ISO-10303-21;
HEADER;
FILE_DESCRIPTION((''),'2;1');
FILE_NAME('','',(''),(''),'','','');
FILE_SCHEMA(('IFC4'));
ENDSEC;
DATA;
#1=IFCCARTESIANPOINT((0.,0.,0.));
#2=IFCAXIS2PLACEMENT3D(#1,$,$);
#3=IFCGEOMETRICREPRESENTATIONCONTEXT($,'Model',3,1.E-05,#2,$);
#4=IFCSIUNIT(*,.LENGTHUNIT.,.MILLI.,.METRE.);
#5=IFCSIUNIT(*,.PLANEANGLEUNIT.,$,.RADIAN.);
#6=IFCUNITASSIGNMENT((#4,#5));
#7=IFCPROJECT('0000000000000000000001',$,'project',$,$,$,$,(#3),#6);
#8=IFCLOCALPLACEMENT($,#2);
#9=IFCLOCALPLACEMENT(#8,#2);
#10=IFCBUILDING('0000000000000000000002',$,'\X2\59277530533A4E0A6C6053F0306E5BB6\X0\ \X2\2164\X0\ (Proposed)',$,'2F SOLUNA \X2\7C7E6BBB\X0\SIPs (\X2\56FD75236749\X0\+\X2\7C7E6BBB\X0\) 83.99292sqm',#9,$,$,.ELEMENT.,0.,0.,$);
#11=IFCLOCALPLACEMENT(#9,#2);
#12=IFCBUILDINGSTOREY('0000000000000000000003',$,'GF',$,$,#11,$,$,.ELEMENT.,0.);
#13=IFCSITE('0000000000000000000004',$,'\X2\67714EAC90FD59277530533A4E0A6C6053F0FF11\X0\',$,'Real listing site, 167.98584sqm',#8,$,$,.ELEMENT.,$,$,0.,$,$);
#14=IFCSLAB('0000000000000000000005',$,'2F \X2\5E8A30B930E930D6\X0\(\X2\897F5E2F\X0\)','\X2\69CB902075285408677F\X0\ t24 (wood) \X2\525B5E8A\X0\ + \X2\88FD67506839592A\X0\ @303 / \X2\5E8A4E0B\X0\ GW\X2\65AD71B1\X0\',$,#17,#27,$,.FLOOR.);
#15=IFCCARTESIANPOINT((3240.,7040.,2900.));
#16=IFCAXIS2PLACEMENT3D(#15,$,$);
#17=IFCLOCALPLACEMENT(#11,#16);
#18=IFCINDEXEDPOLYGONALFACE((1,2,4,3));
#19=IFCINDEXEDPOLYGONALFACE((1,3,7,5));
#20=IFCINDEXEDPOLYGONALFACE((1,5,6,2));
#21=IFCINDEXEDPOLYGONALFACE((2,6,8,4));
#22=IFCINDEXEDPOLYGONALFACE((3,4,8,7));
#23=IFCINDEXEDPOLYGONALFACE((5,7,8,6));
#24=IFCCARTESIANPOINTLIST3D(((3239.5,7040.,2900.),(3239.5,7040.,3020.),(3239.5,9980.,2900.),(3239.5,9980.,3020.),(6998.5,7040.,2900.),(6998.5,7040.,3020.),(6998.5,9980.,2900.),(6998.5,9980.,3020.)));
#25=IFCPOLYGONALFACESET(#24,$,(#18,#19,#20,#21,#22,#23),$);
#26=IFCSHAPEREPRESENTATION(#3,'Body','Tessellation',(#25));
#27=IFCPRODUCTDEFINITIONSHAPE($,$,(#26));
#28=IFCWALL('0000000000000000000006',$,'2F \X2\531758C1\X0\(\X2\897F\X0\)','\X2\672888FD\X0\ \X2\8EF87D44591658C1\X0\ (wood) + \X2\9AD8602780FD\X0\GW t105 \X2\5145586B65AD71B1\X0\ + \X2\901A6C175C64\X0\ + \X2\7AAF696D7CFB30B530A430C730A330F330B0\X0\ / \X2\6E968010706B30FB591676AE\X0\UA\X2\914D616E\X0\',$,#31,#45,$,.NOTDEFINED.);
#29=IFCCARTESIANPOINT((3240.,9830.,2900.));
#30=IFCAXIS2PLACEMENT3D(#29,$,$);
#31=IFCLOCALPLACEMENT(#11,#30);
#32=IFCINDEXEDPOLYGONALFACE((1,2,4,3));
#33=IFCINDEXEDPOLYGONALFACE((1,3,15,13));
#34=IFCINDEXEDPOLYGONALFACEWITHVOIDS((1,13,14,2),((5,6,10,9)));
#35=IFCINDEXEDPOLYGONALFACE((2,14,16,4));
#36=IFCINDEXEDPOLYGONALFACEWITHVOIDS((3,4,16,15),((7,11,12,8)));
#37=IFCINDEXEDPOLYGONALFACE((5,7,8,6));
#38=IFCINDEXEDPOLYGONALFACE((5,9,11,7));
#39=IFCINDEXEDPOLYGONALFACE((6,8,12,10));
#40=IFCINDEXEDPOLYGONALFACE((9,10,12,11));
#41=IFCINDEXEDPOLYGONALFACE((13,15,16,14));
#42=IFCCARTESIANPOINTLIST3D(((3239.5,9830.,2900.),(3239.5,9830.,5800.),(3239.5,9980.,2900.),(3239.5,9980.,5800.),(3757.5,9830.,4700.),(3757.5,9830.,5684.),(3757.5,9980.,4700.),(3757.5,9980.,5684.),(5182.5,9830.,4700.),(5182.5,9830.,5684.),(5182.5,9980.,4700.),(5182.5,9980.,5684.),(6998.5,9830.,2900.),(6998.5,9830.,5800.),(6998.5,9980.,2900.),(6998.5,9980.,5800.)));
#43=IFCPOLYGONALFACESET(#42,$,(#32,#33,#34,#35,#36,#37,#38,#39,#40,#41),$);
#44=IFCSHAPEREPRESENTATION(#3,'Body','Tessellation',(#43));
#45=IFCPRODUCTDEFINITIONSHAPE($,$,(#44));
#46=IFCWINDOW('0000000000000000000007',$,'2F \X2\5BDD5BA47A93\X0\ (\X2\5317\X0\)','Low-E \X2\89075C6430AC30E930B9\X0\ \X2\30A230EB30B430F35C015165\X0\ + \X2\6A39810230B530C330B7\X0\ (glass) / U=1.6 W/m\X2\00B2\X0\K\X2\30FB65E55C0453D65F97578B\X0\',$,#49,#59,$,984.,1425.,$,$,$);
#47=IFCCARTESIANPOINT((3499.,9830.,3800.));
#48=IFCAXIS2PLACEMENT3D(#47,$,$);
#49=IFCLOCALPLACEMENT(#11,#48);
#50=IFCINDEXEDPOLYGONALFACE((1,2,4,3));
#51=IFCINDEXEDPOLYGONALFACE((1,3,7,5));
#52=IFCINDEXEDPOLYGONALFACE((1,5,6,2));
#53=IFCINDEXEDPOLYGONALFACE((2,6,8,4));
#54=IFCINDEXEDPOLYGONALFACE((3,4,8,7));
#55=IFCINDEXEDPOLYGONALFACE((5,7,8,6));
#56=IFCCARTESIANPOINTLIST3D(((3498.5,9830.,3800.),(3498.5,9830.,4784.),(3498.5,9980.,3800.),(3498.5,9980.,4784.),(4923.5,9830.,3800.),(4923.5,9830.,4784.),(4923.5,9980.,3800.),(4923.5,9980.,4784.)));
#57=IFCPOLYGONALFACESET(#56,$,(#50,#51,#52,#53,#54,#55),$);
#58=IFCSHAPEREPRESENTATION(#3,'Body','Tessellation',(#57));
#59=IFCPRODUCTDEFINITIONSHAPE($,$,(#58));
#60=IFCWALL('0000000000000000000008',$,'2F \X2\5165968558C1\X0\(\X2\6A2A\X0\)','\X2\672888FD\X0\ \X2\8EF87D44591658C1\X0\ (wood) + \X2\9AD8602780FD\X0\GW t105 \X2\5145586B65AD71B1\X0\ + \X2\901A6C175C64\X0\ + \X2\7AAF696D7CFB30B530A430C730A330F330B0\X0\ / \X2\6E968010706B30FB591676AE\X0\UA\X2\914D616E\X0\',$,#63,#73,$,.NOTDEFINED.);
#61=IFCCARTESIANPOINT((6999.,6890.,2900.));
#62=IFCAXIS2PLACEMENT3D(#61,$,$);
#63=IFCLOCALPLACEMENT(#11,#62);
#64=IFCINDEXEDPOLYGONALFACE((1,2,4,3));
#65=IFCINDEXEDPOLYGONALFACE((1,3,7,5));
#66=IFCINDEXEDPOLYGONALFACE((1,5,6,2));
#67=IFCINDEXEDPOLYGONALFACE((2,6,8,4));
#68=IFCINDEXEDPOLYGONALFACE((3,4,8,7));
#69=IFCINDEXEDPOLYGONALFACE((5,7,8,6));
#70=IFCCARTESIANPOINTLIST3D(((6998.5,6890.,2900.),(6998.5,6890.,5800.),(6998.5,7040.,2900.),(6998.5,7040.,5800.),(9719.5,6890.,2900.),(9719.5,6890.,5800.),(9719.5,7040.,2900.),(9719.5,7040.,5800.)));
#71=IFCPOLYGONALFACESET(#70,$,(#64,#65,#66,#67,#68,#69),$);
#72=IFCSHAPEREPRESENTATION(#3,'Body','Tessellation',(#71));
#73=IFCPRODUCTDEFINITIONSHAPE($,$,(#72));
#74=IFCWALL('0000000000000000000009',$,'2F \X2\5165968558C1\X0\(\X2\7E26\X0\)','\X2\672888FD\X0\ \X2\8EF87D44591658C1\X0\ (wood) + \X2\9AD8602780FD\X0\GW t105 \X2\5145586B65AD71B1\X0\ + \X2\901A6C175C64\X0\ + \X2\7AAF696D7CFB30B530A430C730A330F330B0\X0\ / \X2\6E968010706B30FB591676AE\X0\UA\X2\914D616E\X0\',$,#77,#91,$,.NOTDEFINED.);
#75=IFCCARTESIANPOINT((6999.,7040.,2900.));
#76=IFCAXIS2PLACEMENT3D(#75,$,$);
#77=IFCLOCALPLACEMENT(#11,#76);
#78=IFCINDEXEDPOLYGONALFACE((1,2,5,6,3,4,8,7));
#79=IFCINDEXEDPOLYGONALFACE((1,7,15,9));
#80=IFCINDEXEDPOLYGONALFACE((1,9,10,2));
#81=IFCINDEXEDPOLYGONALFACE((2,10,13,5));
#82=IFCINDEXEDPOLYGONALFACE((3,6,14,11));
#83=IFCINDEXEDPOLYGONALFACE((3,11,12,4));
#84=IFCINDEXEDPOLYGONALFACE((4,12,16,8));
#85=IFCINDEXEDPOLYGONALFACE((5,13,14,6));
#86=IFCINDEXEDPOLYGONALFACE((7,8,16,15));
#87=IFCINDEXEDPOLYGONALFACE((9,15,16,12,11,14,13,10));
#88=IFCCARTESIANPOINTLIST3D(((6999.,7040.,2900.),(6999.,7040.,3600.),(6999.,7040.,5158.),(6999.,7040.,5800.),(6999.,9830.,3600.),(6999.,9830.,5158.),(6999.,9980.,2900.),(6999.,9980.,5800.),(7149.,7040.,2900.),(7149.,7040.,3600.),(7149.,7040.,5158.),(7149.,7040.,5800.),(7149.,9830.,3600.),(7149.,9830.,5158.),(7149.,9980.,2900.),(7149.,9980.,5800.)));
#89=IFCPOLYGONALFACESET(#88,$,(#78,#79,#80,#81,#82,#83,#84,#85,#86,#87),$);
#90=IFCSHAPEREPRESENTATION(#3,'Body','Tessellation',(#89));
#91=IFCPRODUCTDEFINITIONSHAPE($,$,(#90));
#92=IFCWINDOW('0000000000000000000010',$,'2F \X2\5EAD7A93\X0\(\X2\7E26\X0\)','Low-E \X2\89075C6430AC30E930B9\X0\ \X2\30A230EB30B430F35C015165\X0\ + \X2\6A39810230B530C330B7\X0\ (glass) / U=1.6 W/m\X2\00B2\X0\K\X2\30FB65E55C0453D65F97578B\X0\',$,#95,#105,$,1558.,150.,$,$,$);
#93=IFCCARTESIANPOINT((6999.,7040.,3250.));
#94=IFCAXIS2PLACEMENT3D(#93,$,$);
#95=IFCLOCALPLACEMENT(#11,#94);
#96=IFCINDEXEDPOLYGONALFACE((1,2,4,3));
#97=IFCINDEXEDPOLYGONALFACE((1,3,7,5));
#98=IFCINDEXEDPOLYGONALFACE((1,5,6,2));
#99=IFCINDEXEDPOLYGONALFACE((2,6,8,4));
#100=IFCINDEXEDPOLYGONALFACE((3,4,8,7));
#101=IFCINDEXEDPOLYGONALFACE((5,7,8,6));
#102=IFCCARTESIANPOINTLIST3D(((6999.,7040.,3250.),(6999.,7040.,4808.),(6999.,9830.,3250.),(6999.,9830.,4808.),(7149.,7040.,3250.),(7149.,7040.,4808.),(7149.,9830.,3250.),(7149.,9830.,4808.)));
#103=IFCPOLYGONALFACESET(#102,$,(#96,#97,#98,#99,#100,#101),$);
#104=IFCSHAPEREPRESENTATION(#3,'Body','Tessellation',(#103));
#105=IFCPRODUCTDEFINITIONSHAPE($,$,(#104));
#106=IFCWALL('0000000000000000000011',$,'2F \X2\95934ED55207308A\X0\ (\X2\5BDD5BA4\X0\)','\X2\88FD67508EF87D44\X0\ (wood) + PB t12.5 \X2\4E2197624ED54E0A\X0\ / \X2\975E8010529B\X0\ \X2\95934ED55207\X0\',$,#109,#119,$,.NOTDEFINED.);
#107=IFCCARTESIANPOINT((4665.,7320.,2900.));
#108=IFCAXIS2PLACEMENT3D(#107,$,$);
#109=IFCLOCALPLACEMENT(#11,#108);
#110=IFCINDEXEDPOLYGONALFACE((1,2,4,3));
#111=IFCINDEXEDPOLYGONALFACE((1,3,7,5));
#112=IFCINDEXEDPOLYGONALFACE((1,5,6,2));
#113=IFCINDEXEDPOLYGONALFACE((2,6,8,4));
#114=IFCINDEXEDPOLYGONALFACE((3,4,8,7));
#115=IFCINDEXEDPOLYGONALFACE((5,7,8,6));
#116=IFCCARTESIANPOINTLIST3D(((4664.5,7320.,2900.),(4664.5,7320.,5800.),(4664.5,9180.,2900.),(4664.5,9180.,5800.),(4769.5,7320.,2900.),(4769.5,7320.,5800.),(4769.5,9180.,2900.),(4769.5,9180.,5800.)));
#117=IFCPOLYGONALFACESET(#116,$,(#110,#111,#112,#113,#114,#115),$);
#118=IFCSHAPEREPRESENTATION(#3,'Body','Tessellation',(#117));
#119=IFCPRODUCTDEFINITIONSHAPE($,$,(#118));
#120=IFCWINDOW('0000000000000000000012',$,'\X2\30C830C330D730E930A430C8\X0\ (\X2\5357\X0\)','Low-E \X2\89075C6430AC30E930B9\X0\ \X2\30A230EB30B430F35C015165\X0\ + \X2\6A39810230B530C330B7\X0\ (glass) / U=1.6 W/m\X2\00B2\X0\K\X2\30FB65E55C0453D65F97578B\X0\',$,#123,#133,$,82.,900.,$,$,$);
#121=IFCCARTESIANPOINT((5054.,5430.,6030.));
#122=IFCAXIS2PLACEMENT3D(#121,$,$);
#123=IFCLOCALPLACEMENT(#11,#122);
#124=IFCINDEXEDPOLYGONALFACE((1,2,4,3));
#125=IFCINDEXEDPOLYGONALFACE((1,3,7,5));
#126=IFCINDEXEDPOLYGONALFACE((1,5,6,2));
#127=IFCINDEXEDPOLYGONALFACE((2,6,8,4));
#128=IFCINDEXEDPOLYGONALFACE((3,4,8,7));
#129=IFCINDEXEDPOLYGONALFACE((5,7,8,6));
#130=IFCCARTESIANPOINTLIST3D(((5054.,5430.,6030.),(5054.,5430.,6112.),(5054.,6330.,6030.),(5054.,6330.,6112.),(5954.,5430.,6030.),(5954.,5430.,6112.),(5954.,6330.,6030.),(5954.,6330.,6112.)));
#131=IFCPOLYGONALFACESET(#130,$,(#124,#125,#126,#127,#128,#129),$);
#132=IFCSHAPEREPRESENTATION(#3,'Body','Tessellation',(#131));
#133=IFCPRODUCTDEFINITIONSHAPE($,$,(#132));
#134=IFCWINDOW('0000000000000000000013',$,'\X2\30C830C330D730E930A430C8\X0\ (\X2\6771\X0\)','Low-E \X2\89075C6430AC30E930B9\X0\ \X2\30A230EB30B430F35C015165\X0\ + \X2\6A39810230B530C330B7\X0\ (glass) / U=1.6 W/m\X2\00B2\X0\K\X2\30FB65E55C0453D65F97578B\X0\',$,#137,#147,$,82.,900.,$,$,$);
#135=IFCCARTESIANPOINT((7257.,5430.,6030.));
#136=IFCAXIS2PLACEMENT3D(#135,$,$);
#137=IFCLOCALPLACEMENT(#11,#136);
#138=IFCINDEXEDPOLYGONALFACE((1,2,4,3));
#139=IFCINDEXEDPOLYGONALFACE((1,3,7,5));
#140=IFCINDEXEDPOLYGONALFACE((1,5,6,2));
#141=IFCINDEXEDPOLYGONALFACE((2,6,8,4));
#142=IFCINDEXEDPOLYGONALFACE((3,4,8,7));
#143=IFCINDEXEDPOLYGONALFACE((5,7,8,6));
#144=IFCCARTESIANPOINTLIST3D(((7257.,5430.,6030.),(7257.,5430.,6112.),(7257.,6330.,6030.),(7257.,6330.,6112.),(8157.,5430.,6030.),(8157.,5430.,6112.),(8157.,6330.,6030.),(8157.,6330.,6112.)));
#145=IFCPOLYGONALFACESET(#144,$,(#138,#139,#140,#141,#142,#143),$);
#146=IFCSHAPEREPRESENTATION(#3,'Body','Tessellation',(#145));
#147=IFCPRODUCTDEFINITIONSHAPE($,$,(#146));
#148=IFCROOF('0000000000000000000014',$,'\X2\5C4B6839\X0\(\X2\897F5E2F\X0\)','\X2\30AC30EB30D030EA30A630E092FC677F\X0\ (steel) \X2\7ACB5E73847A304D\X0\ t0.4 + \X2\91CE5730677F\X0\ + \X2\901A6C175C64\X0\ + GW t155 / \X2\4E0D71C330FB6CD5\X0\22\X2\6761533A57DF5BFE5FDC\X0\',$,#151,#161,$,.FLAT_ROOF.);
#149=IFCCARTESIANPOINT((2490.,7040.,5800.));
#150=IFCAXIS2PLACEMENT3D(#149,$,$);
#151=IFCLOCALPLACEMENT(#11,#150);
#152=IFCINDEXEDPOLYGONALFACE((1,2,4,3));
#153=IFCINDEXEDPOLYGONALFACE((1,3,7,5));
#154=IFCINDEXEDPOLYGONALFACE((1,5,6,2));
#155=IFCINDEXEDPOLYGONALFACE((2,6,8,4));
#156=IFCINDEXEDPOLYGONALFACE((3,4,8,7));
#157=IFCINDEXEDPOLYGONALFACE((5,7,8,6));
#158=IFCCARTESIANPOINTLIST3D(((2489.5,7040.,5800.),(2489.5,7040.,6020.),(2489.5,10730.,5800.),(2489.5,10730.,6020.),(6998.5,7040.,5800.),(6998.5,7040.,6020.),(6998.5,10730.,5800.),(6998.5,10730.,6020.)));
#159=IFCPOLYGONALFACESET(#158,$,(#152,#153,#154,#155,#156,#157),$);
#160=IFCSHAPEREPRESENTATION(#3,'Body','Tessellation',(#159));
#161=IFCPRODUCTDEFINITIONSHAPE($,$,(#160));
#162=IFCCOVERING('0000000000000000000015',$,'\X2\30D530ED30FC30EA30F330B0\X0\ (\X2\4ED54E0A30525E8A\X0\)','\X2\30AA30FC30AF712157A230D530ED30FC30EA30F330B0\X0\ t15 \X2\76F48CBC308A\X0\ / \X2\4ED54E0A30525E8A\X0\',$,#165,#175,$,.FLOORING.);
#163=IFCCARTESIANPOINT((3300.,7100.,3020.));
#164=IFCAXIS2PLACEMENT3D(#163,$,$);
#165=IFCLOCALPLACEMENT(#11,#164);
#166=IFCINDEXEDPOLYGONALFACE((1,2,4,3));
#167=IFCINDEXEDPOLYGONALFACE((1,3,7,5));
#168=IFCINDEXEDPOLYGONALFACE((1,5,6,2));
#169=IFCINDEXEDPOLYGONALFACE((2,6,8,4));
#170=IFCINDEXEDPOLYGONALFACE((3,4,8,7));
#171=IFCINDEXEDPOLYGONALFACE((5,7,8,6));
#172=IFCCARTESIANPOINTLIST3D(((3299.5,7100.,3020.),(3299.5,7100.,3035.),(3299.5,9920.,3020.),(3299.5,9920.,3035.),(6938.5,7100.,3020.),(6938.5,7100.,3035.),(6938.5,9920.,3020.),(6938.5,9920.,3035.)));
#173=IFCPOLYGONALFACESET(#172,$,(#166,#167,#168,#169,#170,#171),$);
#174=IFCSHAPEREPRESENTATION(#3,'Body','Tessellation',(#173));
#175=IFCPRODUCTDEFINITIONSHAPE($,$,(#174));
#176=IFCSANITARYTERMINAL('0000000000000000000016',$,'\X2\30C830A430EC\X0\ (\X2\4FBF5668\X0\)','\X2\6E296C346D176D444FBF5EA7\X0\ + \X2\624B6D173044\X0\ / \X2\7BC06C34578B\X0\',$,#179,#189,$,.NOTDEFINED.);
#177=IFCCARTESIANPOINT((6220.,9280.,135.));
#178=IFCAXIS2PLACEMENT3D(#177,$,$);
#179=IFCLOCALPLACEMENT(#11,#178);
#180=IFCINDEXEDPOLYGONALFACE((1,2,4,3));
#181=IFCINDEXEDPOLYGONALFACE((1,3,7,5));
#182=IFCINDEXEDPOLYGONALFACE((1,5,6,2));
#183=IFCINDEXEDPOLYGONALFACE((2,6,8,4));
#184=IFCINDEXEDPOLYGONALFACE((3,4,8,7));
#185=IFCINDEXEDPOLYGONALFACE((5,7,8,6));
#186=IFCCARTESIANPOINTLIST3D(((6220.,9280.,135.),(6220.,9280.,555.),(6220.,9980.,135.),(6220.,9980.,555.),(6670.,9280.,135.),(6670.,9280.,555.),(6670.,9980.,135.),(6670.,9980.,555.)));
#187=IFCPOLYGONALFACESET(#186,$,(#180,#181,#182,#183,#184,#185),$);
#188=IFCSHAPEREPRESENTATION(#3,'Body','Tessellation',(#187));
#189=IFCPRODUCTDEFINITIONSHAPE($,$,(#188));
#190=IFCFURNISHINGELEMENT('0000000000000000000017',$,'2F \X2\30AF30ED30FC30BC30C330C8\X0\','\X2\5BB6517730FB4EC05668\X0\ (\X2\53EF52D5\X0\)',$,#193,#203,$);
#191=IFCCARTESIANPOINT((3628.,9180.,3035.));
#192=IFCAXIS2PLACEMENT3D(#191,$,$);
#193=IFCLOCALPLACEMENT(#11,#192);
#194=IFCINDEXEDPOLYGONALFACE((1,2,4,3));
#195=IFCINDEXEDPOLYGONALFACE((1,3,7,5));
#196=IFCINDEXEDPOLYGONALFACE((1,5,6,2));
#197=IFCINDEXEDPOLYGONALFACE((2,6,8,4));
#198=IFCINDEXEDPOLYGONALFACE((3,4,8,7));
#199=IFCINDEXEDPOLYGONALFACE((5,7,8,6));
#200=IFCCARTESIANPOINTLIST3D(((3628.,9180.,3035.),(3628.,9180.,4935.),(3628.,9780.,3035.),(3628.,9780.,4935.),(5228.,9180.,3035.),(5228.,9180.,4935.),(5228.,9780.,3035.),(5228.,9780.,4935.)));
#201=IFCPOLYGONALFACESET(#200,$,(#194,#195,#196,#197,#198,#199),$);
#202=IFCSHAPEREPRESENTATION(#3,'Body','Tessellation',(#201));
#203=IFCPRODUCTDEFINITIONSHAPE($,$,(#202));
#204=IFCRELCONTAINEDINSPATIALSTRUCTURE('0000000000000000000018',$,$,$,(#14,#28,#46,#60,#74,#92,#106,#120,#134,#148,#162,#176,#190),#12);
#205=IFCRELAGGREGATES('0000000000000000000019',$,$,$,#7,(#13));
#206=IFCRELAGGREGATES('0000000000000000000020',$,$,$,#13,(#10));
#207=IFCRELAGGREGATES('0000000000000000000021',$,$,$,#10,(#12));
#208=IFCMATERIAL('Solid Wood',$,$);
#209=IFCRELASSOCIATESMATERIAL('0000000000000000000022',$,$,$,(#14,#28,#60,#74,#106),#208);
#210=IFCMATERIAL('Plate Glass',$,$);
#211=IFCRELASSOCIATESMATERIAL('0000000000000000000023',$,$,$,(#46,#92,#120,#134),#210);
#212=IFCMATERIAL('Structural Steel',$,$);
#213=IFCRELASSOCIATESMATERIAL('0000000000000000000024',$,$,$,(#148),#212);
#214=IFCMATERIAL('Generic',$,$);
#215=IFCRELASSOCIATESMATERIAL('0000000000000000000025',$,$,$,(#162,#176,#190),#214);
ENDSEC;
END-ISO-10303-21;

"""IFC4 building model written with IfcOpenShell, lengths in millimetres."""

from ifc_helpers import new_model, si_unit, frame, frame_2d, origin, place, context, project, spatial, rectangle, extrude, material, element, fill, save


model = new_model("IFC4")

# Units and contexts
model_context = context("Model", 3, precision=1e-05, world=origin())
ifc_project = project(units=[si_unit("LENGTHUNIT", "METRE", prefix="MILLI"), si_unit("PLANEANGLEUNIT", "RADIAN")], contexts=[model_context])

# Site, building, storey
site_placement = place(None, origin())
site = spatial("IfcSite", under=ifc_project, at=site_placement, Name="東京都大田区上池台１", ObjectType="Real listing site, 167.98584sqm", CompositionType="ELEMENT", RefElevation=0.0)
building_placement = place(site_placement, origin())
building = spatial("IfcBuilding", under=site, at=building_placement, Name="大田区上池台の家 Ⅴ (Proposed)", ObjectType="2F SOLUNA 籾殻SIPs (国産杉+籾殻) 83.99292sqm", CompositionType="ELEMENT", ElevationOfRefHeight=0.0, ElevationOfTerrain=0.0)
storey_placement = place(building_placement, origin())
storey = spatial("IfcBuildingStorey", under=building, at=storey_placement, Name="GF", CompositionType="ELEMENT", Elevation=0.0)

# Slab
ifc_material_1 = material(Name="Solid Wood")
slab_placement = place(storey_placement, frame((3240.0, 7040.0, 2900.0)))
element("IfcSlab", 1, at=slab_placement, inside=storey, material=ifc_material_1, Name="2F 床スラブ(西帯)", Description="構造用合板 t24 (wood) 剛床 + 製材根太 @303 / 床下 GW断熱", PredefinedType="FLOOR", context=model_context, shape_type="SweptSolid", body=[
    extrude(rectangle(XDim=3759.0, YDim=2940.0, at=frame_2d((1879.0, 1470.0))), frame((3240.0, 7040.0, 2900.0)), (0.0, 0.0, 1.0), 120.0),
])

# Wall, opening, window
wall_1_placement = place(storey_placement, frame((3240.0, 9830.0, 2900.0)))
wall_1 = element("IfcWall", 2, at=wall_1_placement, inside=storey, material=ifc_material_1, Name="2F 北壁(西)", Description="木製 軸組外壁 (wood) + 高性能GW t105 充填断熱 + 通気層 + 窯業系サイディング / 準耐火・外皮UA配慮", PredefinedType="NOTDEFINED", context=model_context, shape_type="SweptSolid", body=[
    extrude(rectangle(XDim=3759.0, YDim=150.0, at=frame_2d((1879.0, 75.0))), frame((3240.0, 9830.0, 2900.0)), (0.0, 0.0, 1.0), 2900.0),
])
opening_1_placement = place(storey_placement, frame((3499.0, 9830.0, 3800.0)))
opening_1 = element("IfcOpeningElement", 3, at=opening_1_placement, cuts=wall_1, PredefinedType="NOTDEFINED", context=model_context, shape_type="SweptSolid", body=[
    extrude(rectangle(XDim=1425.0, YDim=150.0, at=frame_2d((712.0, 75.0))), frame((3499.0, 9830.0, 3800.0)), (0.0, 0.0, 1.0), 984.0),
])
ifc_material_2 = material(Name="Plate Glass")
window_1_placement = place(storey_placement, frame((3499.0, 9830.0, 3800.0)))
window_1 = element("IfcWindow", 4, at=window_1_placement, inside=storey, material=ifc_material_2, Name="2F 寝室窓 (北)", Description="Low-E 複層ガラス アルゴン封入 + 樹脂サッシ (glass) / U=1.6 W/m²K・日射取得型", OverallHeight=984.0, OverallWidth=1425.0, context=model_context, shape_type="SweptSolid", body=[
    extrude(rectangle(XDim=1425.0, YDim=150.0, at=frame_2d((712.0, 75.0))), frame((3499.0, 9830.0, 3800.0)), (0.0, 0.0, 1.0), 984.0),
])
fill(opening_1, window_1)

# Wall
wall_2_placement = place(storey_placement, frame((6999.0, 6890.0, 2900.0)))
element("IfcWall", 5, at=wall_2_placement, inside=storey, material=ifc_material_1, Name="2F 入隅壁(横)", Description="木製 軸組外壁 (wood) + 高性能GW t105 充填断熱 + 通気層 + 窯業系サイディング / 準耐火・外皮UA配慮", PredefinedType="NOTDEFINED", context=model_context, shape_type="SweptSolid", body=[
    extrude(rectangle(XDim=2721.0, YDim=150.0, at=frame_2d((1360.0, 75.0))), frame((6999.0, 6890.0, 2900.0)), (0.0, 0.0, 1.0), 2900.0),
])

# Wall, opening, window
wall_3_placement = place(storey_placement, frame((6999.0, 7040.0, 2900.0)))
wall_3 = element("IfcWall", 6, at=wall_3_placement, inside=storey, material=ifc_material_1, Name="2F 入隅壁(縦)", Description="木製 軸組外壁 (wood) + 高性能GW t105 充填断熱 + 通気層 + 窯業系サイディング / 準耐火・外皮UA配慮", PredefinedType="NOTDEFINED", context=model_context, shape_type="SweptSolid", body=[
    extrude(rectangle(XDim=150.0, YDim=2940.0, at=frame_2d((75.0, 1470.0))), frame((6999.0, 7040.0, 2900.0)), (0.0, 0.0, 1.0), 2900.0),
])
opening_2_placement = place(storey_placement, frame((6999.0, 7040.0, 3250.0)))
opening_2 = element("IfcOpeningElement", 7, at=opening_2_placement, cuts=wall_3, PredefinedType="NOTDEFINED", context=model_context, shape_type="SweptSolid", body=[
    extrude(rectangle(XDim=150.0, YDim=2790.0, at=frame_2d((75.0, 1395.0))), frame((6999.0, 7040.0, 3250.0)), (0.0, 0.0, 1.0), 1558.0),
])
window_2_placement = place(storey_placement, frame((6999.0, 7040.0, 3250.0)))
window_2 = element("IfcWindow", 8, at=window_2_placement, inside=storey, material=ifc_material_2, Name="2F 庭窓(縦)", Description="Low-E 複層ガラス アルゴン封入 + 樹脂サッシ (glass) / U=1.6 W/m²K・日射取得型", OverallHeight=1558.0, OverallWidth=150.0, context=model_context, shape_type="SweptSolid", body=[
    extrude(rectangle(XDim=150.0, YDim=2790.0, at=frame_2d((75.0, 1395.0))), frame((6999.0, 7040.0, 3250.0)), (0.0, 0.0, 1.0), 1558.0),
])
fill(opening_2, window_2)

# Wall
wall_4_placement = place(storey_placement, frame((4665.0, 7320.0, 2900.0)))
element("IfcWall", 9, at=wall_4_placement, inside=storey, material=ifc_material_1, Name="2F 間仕切り (寝室)", Description="製材軸組 (wood) + PB t12.5 両面仕上 / 非耐力 間仕切", PredefinedType="NOTDEFINED", context=model_context, shape_type="SweptSolid", body=[
    extrude(rectangle(XDim=105.0, YDim=1860.0, at=frame_2d((52.0, 930.0))), frame((4665.0, 7320.0, 2900.0)), (0.0, 0.0, 1.0), 2900.0),
])

# Windows
window_3_placement = place(storey_placement, frame((5054.0, 5430.0, 6030.0)))
element("IfcWindow", 10, at=window_3_placement, inside=storey, material=ifc_material_2, Name="トップライト (南)", Description="Low-E 複層ガラス アルゴン封入 + 樹脂サッシ (glass) / U=1.6 W/m²K・日射取得型", OverallHeight=82.0, OverallWidth=900.0, context=model_context, shape_type="SweptSolid", body=[
    extrude(rectangle(XDim=900.0, YDim=900.0, at=frame_2d((450.0, 450.0))), frame((5054.0, 5430.0, 6030.0)), (0.0, 0.0, 1.0), 82.0),
])
window_4_placement = place(storey_placement, frame((7257.0, 5430.0, 6030.0)))
element("IfcWindow", 11, at=window_4_placement, inside=storey, material=ifc_material_2, Name="トップライト (東)", Description="Low-E 複層ガラス アルゴン封入 + 樹脂サッシ (glass) / U=1.6 W/m²K・日射取得型", OverallHeight=82.0, OverallWidth=900.0, context=model_context, shape_type="SweptSolid", body=[
    extrude(rectangle(XDim=900.0, YDim=900.0, at=frame_2d((450.0, 450.0))), frame((7257.0, 5430.0, 6030.0)), (0.0, 0.0, 1.0), 82.0),
])

# Roof
ifc_material_3 = material(Name="Structural Steel")
for number, where, name in (
    (12, (2490.0, 7040.0, 5800.0), "屋根(西帯)"),
):
    element("IfcRoof", number, at=place(storey_placement, frame(where)), inside=storey, material=ifc_material_3, Name=name, Description="ガルバリウム鋼板 (steel) 立平葺き t0.4 + 野地板 + 通気層 + GW t155 / 不燃・法22条区域対応", PredefinedType="FLAT_ROOF", context=model_context, shape_type="SweptSolid", body=[
        extrude(rectangle(XDim=4509.0, YDim=3690.0, at=frame_2d((2254.0, 1845.0))), frame((2490.0, 7040.0, 5800.0)), (0.0, 0.0, 1.0), 220.0),
    ])

# Covering
ifc_material_4 = material(Name="Generic")
covering_placement = place(storey_placement, frame((3300.0, 7100.0, 3020.0)))
element("IfcCovering", 13, at=covering_placement, inside=storey, material=ifc_material_4, Name="フローリング (仕上げ床)", Description="オーク無垢フローリング t15 直貼り / 仕上げ床", PredefinedType="FLOORING", context=model_context, shape_type="SweptSolid", body=[
    extrude(rectangle(XDim=3639.0, YDim=2820.0, at=frame_2d((1819.0, 1410.0))), frame((3300.0, 7100.0, 3020.0)), (0.0, 0.0, 1.0), 15.0),
])

# Sanitary terminal
sanitary_terminal_placement = place(storey_placement, frame((6220.0, 9280.0, 135.0)))
element("IfcSanitaryTerminal", 14, at=sanitary_terminal_placement, inside=storey, material=ifc_material_4, Name="トイレ (便器)", Description="温水洗浄便座 + 手洗い / 節水型", PredefinedType="NOTDEFINED", context=model_context, shape_type="SweptSolid", body=[
    extrude(rectangle(XDim=450.0, YDim=700.0, at=frame_2d((225.0, 350.0))), frame((6220.0, 9280.0, 135.0)), (0.0, 0.0, 1.0), 420.0),
])

# Furnishing element
furnishing_1_placement = place(storey_placement, frame((3628.0, 9180.0, 3035.0)))
element("IfcFurnishingElement", 15, at=furnishing_1_placement, inside=storey, material=ifc_material_4, Name="2F クローゼット", Description="家具・什器 (可動)", context=model_context, shape_type="SweptSolid", body=[
    extrude(rectangle(XDim=1600.0, YDim=600.0, at=frame_2d((800.0, 300.0))), frame((3628.0, 9180.0, 3035.0)), (0.0, 0.0, 1.0), 1900.0),
])

save(model, "model.ifc")
